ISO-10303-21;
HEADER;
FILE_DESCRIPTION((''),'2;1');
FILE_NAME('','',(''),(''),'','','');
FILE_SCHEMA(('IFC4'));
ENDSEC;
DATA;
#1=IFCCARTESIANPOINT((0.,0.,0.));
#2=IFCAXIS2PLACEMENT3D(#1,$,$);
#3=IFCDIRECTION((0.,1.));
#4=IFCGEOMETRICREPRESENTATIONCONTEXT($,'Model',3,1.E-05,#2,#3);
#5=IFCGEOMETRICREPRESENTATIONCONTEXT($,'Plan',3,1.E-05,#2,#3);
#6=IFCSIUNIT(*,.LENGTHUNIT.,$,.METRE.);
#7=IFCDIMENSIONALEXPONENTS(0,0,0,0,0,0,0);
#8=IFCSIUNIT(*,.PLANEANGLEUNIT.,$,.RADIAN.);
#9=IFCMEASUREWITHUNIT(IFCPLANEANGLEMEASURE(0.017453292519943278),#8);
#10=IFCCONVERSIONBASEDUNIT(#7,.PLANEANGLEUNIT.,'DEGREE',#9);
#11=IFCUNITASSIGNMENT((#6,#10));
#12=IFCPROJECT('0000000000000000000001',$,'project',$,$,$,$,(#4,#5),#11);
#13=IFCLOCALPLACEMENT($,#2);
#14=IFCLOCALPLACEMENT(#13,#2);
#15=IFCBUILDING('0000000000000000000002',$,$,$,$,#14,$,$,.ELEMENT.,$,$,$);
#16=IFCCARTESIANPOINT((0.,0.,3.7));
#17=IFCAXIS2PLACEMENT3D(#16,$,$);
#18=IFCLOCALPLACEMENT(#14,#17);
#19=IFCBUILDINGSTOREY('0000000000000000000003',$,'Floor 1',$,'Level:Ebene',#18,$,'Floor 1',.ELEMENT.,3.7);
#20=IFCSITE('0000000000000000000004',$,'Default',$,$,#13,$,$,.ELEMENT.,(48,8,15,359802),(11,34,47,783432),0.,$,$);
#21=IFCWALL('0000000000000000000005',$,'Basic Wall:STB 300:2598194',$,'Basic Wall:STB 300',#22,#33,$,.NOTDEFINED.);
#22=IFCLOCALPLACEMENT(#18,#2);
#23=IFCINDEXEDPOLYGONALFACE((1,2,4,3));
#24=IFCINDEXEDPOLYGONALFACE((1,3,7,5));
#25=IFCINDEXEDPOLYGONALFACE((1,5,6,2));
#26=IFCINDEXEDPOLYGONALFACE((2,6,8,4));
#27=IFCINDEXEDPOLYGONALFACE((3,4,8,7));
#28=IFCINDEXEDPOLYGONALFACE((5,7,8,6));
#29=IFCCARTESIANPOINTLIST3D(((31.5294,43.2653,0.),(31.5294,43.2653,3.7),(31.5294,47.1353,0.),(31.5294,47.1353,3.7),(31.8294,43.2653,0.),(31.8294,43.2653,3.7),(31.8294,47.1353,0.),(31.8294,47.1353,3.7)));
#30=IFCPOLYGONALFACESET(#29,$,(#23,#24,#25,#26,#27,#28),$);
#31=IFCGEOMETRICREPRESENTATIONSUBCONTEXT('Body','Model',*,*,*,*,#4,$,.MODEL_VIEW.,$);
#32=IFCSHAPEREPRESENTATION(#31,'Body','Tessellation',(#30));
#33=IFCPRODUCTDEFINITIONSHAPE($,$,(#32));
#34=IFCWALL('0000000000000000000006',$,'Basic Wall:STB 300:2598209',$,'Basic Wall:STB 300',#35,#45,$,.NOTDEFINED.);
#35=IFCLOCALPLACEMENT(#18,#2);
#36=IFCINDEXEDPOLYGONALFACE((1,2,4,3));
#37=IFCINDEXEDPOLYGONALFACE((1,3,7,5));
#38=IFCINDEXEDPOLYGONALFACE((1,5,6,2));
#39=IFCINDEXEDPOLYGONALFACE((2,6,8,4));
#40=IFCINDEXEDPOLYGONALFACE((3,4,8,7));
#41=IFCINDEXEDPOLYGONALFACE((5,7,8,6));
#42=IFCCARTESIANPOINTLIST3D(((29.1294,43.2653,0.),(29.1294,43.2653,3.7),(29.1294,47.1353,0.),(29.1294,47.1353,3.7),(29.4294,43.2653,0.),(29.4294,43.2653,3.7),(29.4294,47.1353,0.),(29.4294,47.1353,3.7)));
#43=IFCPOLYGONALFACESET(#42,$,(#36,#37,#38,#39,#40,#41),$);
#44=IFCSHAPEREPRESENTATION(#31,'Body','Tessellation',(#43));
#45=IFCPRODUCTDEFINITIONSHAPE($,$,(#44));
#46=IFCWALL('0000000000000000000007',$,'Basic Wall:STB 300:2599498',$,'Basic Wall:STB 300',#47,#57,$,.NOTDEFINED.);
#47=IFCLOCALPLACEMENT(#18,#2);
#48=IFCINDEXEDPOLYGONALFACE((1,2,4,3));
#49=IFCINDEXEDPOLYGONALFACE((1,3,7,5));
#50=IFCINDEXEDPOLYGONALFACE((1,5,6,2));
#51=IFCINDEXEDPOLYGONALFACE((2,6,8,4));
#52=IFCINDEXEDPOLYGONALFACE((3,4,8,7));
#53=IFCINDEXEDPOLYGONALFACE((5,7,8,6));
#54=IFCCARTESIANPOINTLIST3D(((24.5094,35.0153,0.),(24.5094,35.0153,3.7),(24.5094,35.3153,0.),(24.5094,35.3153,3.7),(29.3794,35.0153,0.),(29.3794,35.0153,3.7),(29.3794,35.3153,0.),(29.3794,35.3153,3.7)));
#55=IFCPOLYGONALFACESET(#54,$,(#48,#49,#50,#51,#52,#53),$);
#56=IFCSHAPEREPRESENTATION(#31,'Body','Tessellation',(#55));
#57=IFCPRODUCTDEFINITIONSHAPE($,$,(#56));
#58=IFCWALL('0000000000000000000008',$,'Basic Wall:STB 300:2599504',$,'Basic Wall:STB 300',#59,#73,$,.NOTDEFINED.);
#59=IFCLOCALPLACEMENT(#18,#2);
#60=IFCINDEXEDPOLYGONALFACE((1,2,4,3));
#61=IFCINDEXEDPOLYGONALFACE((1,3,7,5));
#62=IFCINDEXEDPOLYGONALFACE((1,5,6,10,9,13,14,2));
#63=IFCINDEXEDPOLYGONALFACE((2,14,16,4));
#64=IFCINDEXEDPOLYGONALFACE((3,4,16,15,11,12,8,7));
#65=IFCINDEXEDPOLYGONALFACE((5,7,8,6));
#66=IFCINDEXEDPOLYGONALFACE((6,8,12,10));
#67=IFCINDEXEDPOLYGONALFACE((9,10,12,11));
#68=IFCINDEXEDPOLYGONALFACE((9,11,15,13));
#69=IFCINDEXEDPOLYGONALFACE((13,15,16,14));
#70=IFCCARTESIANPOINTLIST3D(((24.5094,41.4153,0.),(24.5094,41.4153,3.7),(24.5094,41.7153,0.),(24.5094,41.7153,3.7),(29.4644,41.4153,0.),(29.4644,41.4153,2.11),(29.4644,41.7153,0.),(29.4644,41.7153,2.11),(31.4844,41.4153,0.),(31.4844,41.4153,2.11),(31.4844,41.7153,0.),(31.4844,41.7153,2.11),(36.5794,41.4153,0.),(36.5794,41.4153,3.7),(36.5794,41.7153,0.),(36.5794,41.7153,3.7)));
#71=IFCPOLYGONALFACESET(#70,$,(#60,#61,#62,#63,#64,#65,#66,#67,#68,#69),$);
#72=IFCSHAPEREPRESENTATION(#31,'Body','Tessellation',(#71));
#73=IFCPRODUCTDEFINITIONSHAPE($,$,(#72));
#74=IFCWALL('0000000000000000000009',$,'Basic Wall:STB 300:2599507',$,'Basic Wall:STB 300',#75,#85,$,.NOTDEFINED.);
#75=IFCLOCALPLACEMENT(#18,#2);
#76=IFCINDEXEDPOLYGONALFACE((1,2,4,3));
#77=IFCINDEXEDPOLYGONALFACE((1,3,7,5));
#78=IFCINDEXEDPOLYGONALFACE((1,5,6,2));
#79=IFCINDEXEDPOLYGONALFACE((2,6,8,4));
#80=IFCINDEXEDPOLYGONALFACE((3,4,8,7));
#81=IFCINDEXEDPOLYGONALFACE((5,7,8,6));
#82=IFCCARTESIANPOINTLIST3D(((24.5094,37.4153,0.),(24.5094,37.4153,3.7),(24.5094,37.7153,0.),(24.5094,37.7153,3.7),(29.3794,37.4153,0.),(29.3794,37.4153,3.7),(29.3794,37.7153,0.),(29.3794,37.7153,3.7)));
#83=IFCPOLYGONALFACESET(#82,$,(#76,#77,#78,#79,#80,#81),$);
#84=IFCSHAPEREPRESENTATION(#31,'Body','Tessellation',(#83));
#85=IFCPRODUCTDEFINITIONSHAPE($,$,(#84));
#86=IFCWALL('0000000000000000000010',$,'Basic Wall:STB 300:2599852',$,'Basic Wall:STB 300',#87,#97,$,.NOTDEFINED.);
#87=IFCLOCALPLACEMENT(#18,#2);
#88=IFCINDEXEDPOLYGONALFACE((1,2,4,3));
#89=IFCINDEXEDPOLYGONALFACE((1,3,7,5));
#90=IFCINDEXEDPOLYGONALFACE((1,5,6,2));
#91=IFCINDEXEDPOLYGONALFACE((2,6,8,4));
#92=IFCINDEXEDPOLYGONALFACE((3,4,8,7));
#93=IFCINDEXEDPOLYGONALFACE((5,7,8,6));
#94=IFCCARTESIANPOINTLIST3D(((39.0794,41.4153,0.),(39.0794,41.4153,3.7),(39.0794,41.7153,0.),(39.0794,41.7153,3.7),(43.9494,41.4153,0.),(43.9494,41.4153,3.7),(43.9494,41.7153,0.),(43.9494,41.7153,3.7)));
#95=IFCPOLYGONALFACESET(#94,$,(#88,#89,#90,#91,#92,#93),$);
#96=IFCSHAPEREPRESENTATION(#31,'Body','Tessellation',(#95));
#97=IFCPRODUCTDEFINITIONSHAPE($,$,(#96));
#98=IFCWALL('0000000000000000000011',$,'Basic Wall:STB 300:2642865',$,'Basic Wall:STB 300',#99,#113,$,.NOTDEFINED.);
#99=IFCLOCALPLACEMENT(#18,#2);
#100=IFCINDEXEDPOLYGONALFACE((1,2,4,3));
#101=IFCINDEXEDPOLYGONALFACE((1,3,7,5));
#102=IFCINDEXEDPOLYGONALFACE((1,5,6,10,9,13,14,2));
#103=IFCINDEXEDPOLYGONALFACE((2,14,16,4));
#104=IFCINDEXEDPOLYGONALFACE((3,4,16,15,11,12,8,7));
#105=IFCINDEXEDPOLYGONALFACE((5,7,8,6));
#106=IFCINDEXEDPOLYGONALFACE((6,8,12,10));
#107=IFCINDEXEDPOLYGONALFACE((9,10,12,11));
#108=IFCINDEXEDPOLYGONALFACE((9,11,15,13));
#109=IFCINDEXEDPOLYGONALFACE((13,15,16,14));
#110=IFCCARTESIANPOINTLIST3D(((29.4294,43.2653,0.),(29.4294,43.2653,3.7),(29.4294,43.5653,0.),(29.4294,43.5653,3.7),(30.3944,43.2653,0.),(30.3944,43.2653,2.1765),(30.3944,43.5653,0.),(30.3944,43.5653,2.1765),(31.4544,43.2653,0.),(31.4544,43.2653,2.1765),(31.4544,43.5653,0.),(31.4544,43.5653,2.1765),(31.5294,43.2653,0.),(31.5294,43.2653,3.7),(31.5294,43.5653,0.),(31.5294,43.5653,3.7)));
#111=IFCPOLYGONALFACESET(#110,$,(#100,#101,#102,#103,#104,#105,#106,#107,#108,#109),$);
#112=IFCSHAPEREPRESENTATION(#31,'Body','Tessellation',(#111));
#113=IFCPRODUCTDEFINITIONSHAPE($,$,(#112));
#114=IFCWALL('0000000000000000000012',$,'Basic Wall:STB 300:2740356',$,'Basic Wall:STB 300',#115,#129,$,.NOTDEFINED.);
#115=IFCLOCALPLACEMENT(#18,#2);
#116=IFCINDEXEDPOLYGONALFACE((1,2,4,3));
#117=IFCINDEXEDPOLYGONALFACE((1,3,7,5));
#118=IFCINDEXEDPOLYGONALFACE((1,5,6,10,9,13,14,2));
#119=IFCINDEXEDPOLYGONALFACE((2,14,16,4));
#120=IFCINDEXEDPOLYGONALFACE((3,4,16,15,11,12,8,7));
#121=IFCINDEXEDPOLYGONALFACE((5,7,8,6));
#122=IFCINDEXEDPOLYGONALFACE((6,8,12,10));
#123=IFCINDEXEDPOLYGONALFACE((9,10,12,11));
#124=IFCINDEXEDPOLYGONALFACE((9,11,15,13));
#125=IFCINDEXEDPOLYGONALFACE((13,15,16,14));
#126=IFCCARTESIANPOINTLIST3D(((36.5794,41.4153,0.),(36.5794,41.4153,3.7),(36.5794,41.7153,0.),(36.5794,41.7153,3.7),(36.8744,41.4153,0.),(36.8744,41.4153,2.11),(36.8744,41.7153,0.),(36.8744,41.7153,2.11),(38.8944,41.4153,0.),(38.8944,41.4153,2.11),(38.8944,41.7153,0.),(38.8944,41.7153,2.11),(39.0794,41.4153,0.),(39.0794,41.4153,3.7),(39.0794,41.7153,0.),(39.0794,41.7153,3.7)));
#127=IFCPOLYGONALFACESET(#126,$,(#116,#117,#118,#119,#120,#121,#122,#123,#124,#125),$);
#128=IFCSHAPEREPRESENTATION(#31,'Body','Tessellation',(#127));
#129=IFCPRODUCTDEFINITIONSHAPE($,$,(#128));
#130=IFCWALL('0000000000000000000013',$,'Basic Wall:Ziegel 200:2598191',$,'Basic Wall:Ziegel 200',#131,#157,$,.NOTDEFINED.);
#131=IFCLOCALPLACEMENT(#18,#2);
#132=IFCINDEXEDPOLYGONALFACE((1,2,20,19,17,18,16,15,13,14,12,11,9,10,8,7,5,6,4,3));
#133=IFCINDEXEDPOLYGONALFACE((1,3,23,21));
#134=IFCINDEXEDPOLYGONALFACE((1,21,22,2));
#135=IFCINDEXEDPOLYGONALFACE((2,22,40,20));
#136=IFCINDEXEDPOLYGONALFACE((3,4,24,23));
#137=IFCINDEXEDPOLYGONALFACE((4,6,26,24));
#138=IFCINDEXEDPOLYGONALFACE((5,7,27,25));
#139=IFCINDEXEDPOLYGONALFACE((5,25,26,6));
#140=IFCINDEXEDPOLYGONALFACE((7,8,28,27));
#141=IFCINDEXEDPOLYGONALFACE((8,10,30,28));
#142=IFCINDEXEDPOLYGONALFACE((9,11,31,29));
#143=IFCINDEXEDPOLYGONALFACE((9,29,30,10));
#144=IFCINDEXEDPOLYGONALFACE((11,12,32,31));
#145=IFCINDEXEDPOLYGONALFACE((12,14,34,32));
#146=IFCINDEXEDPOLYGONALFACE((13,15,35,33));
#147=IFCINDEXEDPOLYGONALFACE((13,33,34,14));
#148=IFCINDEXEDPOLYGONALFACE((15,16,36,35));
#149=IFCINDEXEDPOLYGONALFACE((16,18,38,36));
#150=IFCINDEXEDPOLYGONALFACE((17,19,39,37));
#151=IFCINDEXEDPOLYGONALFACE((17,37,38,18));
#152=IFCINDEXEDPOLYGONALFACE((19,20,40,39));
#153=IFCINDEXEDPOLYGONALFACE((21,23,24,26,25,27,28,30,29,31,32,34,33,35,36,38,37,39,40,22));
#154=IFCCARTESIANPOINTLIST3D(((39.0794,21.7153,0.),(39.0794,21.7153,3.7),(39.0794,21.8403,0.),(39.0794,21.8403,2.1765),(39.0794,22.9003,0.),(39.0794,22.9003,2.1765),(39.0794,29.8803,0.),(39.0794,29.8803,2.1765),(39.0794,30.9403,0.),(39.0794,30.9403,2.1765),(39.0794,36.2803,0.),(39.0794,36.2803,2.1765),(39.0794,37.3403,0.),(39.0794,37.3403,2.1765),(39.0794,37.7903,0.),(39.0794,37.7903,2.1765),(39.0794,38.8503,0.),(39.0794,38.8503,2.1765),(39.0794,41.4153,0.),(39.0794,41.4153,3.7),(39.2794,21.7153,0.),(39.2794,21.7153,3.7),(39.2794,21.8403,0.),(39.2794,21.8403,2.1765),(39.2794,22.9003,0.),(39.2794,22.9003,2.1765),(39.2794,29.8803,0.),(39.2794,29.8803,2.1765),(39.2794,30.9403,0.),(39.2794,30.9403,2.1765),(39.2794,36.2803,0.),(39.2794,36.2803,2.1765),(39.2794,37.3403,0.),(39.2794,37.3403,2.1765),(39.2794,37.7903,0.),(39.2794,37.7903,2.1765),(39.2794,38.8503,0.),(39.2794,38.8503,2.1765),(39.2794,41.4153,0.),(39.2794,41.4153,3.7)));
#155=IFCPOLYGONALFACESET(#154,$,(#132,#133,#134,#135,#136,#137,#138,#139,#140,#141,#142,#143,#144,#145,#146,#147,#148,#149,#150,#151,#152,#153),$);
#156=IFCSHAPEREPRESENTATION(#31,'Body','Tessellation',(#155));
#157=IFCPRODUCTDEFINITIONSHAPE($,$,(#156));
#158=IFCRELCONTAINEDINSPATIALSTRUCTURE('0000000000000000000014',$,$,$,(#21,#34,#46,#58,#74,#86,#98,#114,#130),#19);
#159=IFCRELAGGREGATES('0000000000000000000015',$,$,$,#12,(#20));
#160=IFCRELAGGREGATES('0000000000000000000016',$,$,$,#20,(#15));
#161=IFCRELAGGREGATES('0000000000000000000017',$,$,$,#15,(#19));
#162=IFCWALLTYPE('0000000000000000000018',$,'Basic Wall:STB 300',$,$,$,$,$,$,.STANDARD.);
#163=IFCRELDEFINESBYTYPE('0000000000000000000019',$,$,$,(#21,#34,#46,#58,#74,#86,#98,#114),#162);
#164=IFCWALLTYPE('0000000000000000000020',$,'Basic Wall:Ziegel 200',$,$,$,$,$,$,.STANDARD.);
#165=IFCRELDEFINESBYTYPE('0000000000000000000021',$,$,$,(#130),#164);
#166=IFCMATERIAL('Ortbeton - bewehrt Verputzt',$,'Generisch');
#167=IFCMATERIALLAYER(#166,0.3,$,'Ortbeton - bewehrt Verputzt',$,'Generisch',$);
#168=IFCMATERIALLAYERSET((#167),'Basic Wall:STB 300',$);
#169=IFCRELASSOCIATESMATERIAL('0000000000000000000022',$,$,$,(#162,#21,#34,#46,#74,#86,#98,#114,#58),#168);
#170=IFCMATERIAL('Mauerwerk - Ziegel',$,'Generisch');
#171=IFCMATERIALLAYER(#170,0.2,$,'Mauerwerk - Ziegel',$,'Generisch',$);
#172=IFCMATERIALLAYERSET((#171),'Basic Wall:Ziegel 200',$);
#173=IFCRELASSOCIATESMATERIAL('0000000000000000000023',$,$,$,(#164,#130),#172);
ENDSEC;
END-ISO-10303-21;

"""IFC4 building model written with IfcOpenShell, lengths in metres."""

from ifc_helpers import new_model, entity, si_unit, converted_unit, direction, frame, frame_2d, origin, place, context, subcontext, project, spatial, rectangle, extrude, material, layer, layer_set, layer_usage, type_object, element, save


model = new_model("IFC4")

# Units and contexts
model_context = context("Model", 3, precision=1e-05, world=origin(), true_north=direction((0.0, 1.0)))
plan_context = context("Plan", 3, precision=1e-05, world=origin(), true_north=direction((0.0, 1.0)))
body_context = subcontext(model_context, "Body", "Model", "MODEL_VIEW")
ifc_project = project(units=[si_unit("LENGTHUNIT", "METRE"), converted_unit("PLANEANGLEUNIT", "DEGREE", entity("IfcPlaneAngleMeasure", 0.017453292519943278), si_unit("PLANEANGLEUNIT", "RADIAN"), dimensions=[0, 0, 0, 0, 0, 0, 0])], contexts=[model_context, plan_context])

# Site, building, storey
site_placement = place(None, origin())
site = spatial("IfcSite", under=ifc_project, at=site_placement, Name="Default", CompositionType="ELEMENT", RefLatitude=(48, 8, 15, 359802), RefLongitude=(11, 34, 47, 783432), RefElevation=0.0)
building_placement = place(site_placement, origin())
building = spatial("IfcBuilding", under=site, at=building_placement, CompositionType="ELEMENT")
storey_placement = place(building_placement, frame((0.0, 0.0, 3.7)))
storey = spatial("IfcBuildingStorey", under=building, at=storey_placement, Name="Floor 1", ObjectType="Level:Ebene", LongName="Floor 1", CompositionType="ELEMENT", Elevation=3.7)

# Walls
ifc_material_1 = material(Name="Ortbeton - bewehrt Verputzt", Category="Generisch")
ifc_layer_1 = layer(ifc_material_1, 0.3, Name="Ortbeton - bewehrt Verputzt", Category="Generisch")
ifc_layer_set_1 = layer_set([ifc_layer_1], Name="Basic Wall:STB 300")
ifc_layer_usage_1 = layer_usage(ifc_layer_set_1, "AXIS2", "NEGATIVE", 0.15)
wall_type_1 = type_object("IfcWallType", Name="Basic Wall:STB 300", PredefinedType="STANDARD", material=ifc_layer_set_1)
wall_1_placement = place(storey_placement, frame((31.6794, 47.1353, 0.0), z_axis=(0.0, 0.0, 1.0), x_axis=(0.0, -1.0, 0.0)))
element("IfcWall", 1, at=wall_1_placement, inside=storey, type_object=wall_type_1, material=ifc_layer_usage_1, Name="Basic Wall:STB 300:2598194", ObjectType="Basic Wall:STB 300", PredefinedType="NOTDEFINED", context=body_context, shape_type="SweptSolid", body=[
    extrude(rectangle(XDim=3.87, YDim=0.3, at=frame_2d((1.935, 0.0), x_axis=(-1.0, 0.0))), origin(), (0.0, 0.0, 1.0), 3.7),
])
wall_2_placement = place(storey_placement, frame((29.2794, 43.2653, 0.0), z_axis=(0.0, 0.0, 1.0), x_axis=(0.0, 1.0, 0.0)))
element("IfcWall", 2, at=wall_2_placement, inside=storey, type_object=wall_type_1, material=ifc_layer_usage_1, Name="Basic Wall:STB 300:2598209", ObjectType="Basic Wall:STB 300", PredefinedType="NOTDEFINED", context=body_context, shape_type="SweptSolid", body=[
    extrude(rectangle(XDim=3.87, YDim=0.3, at=frame_2d((1.935, 0.0), x_axis=(-1.0, 0.0))), origin(), (0.0, 0.0, 1.0), 3.7),
])
wall_3_placement = place(storey_placement, frame((29.3794, 35.1653, 0.0), z_axis=(0.0, 0.0, 1.0), x_axis=(-1.0, 0.0, 0.0)))
element("IfcWall", 3, at=wall_3_placement, inside=storey, type_object=wall_type_1, material=ifc_layer_usage_1, Name="Basic Wall:STB 300:2599498", ObjectType="Basic Wall:STB 300", PredefinedType="NOTDEFINED", context=body_context, shape_type="SweptSolid", body=[
    extrude(rectangle(XDim=4.87, YDim=0.3, at=frame_2d((2.435, 0.0), x_axis=(-1.0, 0.0))), origin(), (0.0, 0.0, 1.0), 3.7),
])

# Wall, opening
ifc_layer_usage_2 = layer_usage(ifc_layer_set_1, "AXIS2", "POSITIVE", -0.15)
wall_4_placement = place(storey_placement, frame((24.5094, 41.5653, 0.0)))
wall_4 = element("IfcWall", 4, at=wall_4_placement, inside=storey, type_object=wall_type_1, material=ifc_layer_usage_2, Name="Basic Wall:STB 300:2599504", ObjectType="Basic Wall:STB 300", PredefinedType="NOTDEFINED", context=body_context, shape_type="SweptSolid", body=[
    extrude(rectangle(XDim=12.07, YDim=0.3, at=frame_2d((6.035, 0.0), x_axis=(-1.0, 0.0))), origin(), (0.0, 0.0, 1.0), 3.7),
])
opening_1_placement = place(wall_4_placement, frame((6.975, 0.15, 0.0)))
element("IfcOpeningElement", 5, at=opening_1_placement, cuts=wall_4, PredefinedType="OPENING", context=body_context, shape_type="SweptSolid", body=[
    extrude(rectangle(XDim=2.11, YDim=2.02, at=frame_2d((1.055, 1.01), x_axis=(1.0, 0.0))), frame((0.0, 0.0, 0.0), z_axis=(0.0, -1.0, 0.0), x_axis=(0.0, 0.0, 1.0)), (0.0, 0.0, 1.0), 0.3),
])

# Walls
wall_5_placement = place(storey_placement, frame((29.3794, 37.5653, 0.0), z_axis=(0.0, 0.0, 1.0), x_axis=(-1.0, 0.0, 0.0)))
element("IfcWall", 6, at=wall_5_placement, inside=storey, type_object=wall_type_1, material=ifc_layer_usage_1, Name="Basic Wall:STB 300:2599507", ObjectType="Basic Wall:STB 300", PredefinedType="NOTDEFINED", context=body_context, shape_type="SweptSolid", body=[
    extrude(rectangle(XDim=4.87, YDim=0.3, at=frame_2d((2.435, 0.0), x_axis=(-1.0, 0.0))), origin(), (0.0, 0.0, 1.0), 3.7),
])
wall_6_placement = place(storey_placement, frame((39.0794, 41.5653, 0.0)))
element("IfcWall", 7, at=wall_6_placement, inside=storey, type_object=wall_type_1, material=ifc_layer_usage_1, Name="Basic Wall:STB 300:2599852", ObjectType="Basic Wall:STB 300", PredefinedType="NOTDEFINED", context=body_context, shape_type="SweptSolid", body=[
    extrude(rectangle(XDim=4.87, YDim=0.3, at=frame_2d((2.435, 0.0), x_axis=(-1.0, 0.0))), origin(), (0.0, 0.0, 1.0), 3.7),
])

# Walls, openings
wall_7_placement = place(storey_placement, frame((29.4294, 43.4153, 0.0)))
wall_7 = element("IfcWall", 8, at=wall_7_placement, inside=storey, type_object=wall_type_1, material=ifc_layer_usage_1, Name="Basic Wall:STB 300:2642865", ObjectType="Basic Wall:STB 300", PredefinedType="NOTDEFINED", context=body_context, shape_type="SweptSolid", body=[
    extrude(rectangle(XDim=2.1, YDim=0.3, at=frame_2d((1.05, 0.0), x_axis=(1.0, 0.0))), origin(), (0.0, 0.0, 1.0), 3.7),
])
opening_2_placement = place(wall_7_placement, frame((2.025, 0.15, 0.0)))
element("IfcOpeningElement", 9, at=opening_2_placement, cuts=wall_7, PredefinedType="OPENING", context=body_context, shape_type="SweptSolid", body=[
    extrude(rectangle(XDim=2.1765, YDim=1.06, at=frame_2d((1.0882, 0.53), x_axis=(1.0, 0.0))), frame((0.0, 0.0, 0.0), z_axis=(0.0, -1.0, 0.0), x_axis=(0.0, 0.0, 1.0)), (0.0, 0.0, 1.0), 0.3),
])
wall_8_placement = place(storey_placement, frame((36.5794, 41.5653, 0.0)))
wall_8 = element("IfcWall", 10, at=wall_8_placement, inside=storey, type_object=wall_type_1, material=ifc_layer_usage_1, Name="Basic Wall:STB 300:2740356", ObjectType="Basic Wall:STB 300", PredefinedType="NOTDEFINED", context=body_context, shape_type="SweptSolid", body=[
    extrude(rectangle(XDim=2.5, YDim=0.3, at=frame_2d((1.25, 0.0), x_axis=(-1.0, 0.0))), origin(), (0.0, 0.0, 1.0), 3.7),
])
opening_3_placement = place(wall_8_placement, frame((2.315, 0.15, 0.0)))
element("IfcOpeningElement", 11, at=opening_3_placement, cuts=wall_8, PredefinedType="OPENING", context=body_context, shape_type="SweptSolid", body=[
    extrude(rectangle(XDim=2.11, YDim=2.02, at=frame_2d((1.055, 1.01), x_axis=(1.0, 0.0))), frame((0.0, 0.0, 0.0), z_axis=(0.0, -1.0, 0.0), x_axis=(0.0, 0.0, 1.0)), (0.0, 0.0, 1.0), 0.3),
])

# Wall, openings
ifc_material_2 = material(Name="Mauerwerk - Ziegel", Category="Generisch")
ifc_layer_2 = layer(ifc_material_2, 0.2, Name="Mauerwerk - Ziegel", Category="Generisch")
ifc_layer_set_2 = layer_set([ifc_layer_2], Name="Basic Wall:Ziegel 200")
ifc_layer_usage_3 = layer_usage(ifc_layer_set_2, "AXIS2", "NEGATIVE", 0.1)
wall_type_2 = type_object("IfcWallType", Name="Basic Wall:Ziegel 200", PredefinedType="STANDARD", material=ifc_layer_set_2)
wall_9_placement = place(storey_placement, frame((39.1794, 41.4153, 0.0), z_axis=(0.0, 0.0, 1.0), x_axis=(0.0, -1.0, 0.0)))
wall_9 = element("IfcWall", 12, at=wall_9_placement, inside=storey, type_object=wall_type_2, material=ifc_layer_usage_3, Name="Basic Wall:Ziegel 200:2598191", ObjectType="Basic Wall:Ziegel 200", PredefinedType="NOTDEFINED", context=body_context, shape_type="SweptSolid", body=[
    extrude(rectangle(XDim=19.7, YDim=0.2, at=frame_2d((9.85, 0.0), x_axis=(-1.0, 0.0))), origin(), (0.0, 0.0, 1.0), 3.7),
])
opening_4_placement = place(wall_9_placement, frame((11.535, 0.1, 0.0)))
element("IfcOpeningElement", 13, at=opening_4_placement, cuts=wall_9, PredefinedType="OPENING", context=body_context, shape_type="SweptSolid", body=[
    extrude(rectangle(XDim=2.1765, YDim=1.06, at=frame_2d((1.0882, 0.53), x_axis=(1.0, 0.0))), frame((0.0, 0.0, 0.0), z_axis=(0.0, -1.0, 0.0), x_axis=(0.0, 0.0, 1.0)), (0.0, 0.0, 1.0), 0.2),
])
opening_5_placement = place(wall_9_placement, frame((5.135, 0.1, 0.0)))
element("IfcOpeningElement", 14, at=opening_5_placement, cuts=wall_9, PredefinedType="OPENING", context=body_context, shape_type="SweptSolid", body=[
    extrude(rectangle(XDim=2.1765, YDim=1.06, at=frame_2d((1.0882, 0.53), x_axis=(1.0, 0.0))), frame((0.0, 0.0, 0.0), z_axis=(0.0, -1.0, 0.0), x_axis=(0.0, 0.0, 1.0)), (0.0, 0.0, 1.0), 0.2),
])
opening_6_placement = place(wall_9_placement, frame((3.625, 0.1, 0.0)))
element("IfcOpeningElement", 15, at=opening_6_placement, cuts=wall_9, PredefinedType="OPENING", context=body_context, shape_type="SweptSolid", body=[
    extrude(rectangle(XDim=2.1765, YDim=1.06, at=frame_2d((1.0882, 0.53), x_axis=(1.0, 0.0))), frame((0.0, 0.0, 0.0), z_axis=(0.0, -1.0, 0.0), x_axis=(0.0, 0.0, 1.0)), (0.0, 0.0, 1.0), 0.2),
])
opening_7_placement = place(wall_9_placement, frame((19.575, 0.1, 0.0)))
element("IfcOpeningElement", 16, at=opening_7_placement, cuts=wall_9, PredefinedType="OPENING", context=body_context, shape_type="SweptSolid", body=[
    extrude(rectangle(XDim=2.1765, YDim=1.06, at=frame_2d((1.0882, 0.53), x_axis=(1.0, 0.0))), frame((0.0, 0.0, 0.0), z_axis=(0.0, -1.0, 0.0), x_axis=(0.0, 0.0, 1.0)), (0.0, 0.0, 1.0), 0.2),
])

save(model, "model.ifc")
